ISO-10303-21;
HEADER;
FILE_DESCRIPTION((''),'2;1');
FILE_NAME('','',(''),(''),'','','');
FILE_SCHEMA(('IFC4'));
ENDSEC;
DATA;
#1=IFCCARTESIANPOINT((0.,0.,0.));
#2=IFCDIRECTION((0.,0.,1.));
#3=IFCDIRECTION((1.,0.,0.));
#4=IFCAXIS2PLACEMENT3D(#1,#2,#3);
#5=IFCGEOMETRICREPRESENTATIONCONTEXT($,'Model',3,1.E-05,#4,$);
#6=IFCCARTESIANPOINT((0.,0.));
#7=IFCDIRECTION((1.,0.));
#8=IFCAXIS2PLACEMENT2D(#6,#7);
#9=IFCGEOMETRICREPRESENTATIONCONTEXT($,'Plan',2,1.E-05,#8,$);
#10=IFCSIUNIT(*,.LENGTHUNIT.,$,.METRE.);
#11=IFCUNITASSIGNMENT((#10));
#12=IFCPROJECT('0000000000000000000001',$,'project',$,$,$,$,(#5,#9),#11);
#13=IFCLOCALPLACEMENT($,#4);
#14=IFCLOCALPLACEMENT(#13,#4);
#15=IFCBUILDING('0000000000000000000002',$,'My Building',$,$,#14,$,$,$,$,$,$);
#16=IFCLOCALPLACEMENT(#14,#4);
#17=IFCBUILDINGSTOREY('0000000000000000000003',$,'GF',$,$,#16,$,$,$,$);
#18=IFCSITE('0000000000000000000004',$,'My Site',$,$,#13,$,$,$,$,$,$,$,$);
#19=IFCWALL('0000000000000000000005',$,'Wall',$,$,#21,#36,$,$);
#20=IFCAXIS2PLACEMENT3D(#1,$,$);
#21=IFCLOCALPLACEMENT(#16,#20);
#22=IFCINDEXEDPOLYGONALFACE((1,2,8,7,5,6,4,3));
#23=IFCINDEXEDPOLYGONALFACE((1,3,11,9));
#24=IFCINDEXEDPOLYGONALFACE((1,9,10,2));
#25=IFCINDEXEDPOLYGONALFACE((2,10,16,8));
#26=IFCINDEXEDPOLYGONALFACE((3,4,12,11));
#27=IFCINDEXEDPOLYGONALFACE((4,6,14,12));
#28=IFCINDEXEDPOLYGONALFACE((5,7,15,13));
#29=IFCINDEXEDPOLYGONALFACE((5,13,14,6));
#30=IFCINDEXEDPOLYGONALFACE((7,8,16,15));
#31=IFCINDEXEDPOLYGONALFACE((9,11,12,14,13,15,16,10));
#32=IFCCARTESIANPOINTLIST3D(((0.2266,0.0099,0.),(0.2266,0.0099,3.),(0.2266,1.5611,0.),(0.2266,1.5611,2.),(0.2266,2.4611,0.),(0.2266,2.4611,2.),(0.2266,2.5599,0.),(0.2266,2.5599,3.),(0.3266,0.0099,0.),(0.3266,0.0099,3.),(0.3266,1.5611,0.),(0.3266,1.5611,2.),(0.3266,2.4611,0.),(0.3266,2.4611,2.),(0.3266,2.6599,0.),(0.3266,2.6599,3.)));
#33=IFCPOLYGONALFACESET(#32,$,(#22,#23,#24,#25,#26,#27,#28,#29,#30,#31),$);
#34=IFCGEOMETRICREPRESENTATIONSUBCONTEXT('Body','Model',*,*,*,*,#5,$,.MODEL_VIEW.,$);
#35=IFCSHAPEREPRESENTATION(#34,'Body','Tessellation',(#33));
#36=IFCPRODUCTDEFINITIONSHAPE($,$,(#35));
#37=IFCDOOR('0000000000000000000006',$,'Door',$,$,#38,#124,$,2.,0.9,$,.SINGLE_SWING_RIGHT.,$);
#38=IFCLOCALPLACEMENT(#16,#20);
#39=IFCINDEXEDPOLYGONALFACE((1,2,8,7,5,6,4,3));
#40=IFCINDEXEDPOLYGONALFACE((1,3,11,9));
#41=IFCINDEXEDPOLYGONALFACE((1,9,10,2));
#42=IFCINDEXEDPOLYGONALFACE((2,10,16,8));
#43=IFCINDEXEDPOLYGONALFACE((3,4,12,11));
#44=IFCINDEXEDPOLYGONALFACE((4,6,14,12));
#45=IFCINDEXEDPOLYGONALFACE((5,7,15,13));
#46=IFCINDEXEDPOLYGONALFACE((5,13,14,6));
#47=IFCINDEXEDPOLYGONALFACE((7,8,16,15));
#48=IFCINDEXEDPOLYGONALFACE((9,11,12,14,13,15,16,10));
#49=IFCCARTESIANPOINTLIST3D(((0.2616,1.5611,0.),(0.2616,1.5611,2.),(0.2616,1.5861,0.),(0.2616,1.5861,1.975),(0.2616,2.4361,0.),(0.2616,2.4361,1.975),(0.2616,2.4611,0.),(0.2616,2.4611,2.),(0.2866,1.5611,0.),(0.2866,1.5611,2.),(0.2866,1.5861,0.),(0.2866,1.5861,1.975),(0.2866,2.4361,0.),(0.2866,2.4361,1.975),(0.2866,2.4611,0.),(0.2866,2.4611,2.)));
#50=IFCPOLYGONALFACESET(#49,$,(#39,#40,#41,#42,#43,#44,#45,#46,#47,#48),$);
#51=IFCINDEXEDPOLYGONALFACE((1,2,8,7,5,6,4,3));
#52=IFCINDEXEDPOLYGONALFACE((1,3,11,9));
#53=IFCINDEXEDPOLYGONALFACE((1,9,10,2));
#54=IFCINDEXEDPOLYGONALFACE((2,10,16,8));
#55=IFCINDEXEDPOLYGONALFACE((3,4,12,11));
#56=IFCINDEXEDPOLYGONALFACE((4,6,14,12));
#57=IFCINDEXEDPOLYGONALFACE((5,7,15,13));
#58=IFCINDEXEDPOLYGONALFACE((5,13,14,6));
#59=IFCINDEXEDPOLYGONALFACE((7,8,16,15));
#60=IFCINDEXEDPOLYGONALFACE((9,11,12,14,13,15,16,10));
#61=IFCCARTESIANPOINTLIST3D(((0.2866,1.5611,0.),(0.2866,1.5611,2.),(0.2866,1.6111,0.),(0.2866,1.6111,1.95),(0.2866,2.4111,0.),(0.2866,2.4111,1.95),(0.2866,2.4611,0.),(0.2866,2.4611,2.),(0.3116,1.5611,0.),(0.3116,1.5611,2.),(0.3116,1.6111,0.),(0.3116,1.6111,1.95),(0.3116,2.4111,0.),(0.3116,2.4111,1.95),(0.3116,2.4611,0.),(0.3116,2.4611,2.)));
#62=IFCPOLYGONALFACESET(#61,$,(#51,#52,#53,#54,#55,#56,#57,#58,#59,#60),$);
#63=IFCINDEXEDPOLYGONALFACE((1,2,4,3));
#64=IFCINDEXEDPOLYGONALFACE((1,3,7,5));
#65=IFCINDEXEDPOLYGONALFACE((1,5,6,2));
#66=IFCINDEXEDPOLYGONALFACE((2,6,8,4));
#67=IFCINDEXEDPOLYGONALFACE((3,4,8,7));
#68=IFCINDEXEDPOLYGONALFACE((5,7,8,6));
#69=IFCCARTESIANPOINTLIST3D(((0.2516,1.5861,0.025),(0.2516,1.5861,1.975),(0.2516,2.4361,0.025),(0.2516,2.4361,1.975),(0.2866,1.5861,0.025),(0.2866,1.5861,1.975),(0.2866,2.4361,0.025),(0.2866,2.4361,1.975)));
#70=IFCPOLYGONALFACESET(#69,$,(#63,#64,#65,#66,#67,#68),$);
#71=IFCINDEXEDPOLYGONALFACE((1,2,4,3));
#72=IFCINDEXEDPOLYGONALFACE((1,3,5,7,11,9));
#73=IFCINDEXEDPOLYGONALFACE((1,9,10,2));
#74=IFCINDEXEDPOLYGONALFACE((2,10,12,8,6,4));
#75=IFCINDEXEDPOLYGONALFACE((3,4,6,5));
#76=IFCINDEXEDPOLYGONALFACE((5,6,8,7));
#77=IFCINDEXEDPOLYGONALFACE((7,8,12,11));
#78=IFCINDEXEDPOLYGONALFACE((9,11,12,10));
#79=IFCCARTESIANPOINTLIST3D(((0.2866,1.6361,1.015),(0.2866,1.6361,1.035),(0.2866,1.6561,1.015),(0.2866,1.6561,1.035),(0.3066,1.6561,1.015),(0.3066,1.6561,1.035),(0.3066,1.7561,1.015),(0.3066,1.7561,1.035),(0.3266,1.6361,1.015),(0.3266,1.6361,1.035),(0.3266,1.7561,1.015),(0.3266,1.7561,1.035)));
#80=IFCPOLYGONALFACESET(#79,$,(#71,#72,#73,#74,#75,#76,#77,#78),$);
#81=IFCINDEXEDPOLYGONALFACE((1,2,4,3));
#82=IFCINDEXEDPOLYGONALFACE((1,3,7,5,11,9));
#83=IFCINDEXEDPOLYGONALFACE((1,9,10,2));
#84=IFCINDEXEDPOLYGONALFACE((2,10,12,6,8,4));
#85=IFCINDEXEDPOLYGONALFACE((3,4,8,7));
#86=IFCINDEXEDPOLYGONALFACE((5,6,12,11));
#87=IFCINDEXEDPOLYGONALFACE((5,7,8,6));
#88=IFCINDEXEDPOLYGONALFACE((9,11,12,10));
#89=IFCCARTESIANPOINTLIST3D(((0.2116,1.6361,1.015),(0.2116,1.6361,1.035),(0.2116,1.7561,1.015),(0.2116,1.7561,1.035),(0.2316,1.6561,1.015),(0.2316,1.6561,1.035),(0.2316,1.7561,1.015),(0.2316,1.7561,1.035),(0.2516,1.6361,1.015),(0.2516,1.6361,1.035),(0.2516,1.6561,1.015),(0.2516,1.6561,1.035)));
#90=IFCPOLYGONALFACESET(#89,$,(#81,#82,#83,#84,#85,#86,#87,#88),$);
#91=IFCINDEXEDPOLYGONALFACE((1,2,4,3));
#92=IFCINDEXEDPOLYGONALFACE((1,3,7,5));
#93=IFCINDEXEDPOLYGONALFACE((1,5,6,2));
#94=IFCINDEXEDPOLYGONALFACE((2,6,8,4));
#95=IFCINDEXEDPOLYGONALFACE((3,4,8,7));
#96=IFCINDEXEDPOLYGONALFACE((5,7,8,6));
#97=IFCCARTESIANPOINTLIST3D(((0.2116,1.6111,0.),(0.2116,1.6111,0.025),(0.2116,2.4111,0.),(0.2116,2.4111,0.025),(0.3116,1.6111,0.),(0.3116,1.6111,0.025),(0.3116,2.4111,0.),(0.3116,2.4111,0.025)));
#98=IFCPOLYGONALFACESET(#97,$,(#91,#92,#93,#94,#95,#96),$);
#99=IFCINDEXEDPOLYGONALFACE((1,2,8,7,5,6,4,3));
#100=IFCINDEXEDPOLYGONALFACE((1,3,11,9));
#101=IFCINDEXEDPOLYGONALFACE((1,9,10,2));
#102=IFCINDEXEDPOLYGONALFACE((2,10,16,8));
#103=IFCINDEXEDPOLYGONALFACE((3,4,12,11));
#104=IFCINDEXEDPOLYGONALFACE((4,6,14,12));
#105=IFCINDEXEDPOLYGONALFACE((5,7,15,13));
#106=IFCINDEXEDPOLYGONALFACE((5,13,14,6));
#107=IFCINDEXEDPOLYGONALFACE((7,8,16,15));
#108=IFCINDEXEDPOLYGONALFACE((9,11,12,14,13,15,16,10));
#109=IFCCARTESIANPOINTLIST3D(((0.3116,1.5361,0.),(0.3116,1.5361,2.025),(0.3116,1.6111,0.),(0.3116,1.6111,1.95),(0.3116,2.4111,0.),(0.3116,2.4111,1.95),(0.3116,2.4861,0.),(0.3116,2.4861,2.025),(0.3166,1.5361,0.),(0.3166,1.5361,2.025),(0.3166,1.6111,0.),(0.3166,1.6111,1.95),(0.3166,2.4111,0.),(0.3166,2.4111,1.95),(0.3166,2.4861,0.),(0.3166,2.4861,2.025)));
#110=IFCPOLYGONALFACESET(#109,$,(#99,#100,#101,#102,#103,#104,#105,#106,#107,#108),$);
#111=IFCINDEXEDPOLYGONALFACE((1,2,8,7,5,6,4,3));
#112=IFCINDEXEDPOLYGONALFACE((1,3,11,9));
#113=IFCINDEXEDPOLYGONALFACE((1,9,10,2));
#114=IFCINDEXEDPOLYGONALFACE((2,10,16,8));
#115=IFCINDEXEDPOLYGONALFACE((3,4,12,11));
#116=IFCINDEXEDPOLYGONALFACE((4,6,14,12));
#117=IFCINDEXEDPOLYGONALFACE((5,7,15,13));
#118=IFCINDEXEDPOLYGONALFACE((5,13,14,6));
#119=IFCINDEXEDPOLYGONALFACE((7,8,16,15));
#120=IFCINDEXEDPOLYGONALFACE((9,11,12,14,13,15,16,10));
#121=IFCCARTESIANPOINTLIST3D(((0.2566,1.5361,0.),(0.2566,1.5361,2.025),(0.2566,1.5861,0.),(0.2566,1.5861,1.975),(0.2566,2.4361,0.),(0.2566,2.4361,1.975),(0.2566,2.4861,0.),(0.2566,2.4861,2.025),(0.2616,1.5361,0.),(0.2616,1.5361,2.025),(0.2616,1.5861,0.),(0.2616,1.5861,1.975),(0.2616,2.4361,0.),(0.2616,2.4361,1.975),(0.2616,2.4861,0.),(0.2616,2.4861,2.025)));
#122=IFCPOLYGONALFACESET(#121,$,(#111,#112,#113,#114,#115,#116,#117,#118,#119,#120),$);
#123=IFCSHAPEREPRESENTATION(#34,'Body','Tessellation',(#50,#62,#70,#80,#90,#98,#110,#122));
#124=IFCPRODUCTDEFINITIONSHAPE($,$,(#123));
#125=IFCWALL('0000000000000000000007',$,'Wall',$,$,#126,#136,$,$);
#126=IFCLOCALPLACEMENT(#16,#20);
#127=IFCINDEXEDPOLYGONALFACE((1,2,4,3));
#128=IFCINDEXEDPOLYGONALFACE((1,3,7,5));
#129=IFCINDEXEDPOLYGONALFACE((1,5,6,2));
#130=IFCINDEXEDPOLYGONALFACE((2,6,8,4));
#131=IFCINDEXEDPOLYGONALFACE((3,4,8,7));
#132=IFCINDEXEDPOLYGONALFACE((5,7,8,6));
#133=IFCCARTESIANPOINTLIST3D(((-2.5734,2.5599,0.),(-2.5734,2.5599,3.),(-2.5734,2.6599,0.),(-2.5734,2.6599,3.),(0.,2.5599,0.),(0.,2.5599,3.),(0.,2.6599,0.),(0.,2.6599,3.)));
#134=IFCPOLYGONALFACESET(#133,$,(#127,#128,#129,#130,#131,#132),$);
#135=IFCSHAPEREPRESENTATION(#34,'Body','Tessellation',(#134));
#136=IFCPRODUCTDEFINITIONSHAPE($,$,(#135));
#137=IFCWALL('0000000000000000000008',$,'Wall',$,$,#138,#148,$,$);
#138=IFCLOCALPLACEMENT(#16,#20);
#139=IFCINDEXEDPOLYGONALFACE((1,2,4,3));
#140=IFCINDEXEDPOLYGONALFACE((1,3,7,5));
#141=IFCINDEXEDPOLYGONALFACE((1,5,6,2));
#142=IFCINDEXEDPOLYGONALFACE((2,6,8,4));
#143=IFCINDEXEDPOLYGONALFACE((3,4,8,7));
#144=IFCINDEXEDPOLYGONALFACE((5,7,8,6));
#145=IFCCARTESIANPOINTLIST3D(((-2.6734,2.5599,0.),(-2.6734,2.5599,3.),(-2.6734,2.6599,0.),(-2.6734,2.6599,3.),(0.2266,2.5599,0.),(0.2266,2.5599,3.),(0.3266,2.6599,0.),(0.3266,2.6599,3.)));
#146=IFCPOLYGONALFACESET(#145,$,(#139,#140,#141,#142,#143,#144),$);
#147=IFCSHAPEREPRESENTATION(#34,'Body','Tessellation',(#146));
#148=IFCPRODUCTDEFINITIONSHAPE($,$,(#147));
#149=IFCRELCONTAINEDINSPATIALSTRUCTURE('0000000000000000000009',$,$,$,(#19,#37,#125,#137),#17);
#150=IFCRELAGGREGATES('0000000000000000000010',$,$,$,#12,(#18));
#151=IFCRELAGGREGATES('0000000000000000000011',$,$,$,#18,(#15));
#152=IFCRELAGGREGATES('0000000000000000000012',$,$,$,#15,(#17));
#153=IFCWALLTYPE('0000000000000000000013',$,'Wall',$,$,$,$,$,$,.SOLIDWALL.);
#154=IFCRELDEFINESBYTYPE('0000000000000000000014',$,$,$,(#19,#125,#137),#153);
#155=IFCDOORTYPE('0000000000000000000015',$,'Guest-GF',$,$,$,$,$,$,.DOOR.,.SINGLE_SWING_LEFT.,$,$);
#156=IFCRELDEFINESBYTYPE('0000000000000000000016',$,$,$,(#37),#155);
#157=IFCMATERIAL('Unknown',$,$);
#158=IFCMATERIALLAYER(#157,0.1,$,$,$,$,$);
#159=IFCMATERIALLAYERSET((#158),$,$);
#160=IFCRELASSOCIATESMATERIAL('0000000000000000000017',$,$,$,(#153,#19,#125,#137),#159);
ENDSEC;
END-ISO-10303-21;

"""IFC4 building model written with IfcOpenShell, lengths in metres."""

from ifc_helpers import new_model, entity, si_unit, frame, origin_with_axes, origin_2d_with_axis, place, context, subcontext, project, spatial, line, indexed_curve, outline, extrude, shape, source, transform, mapped, material, layer, layer_set, layer_usage, type_object, type_shapes, element, fill, save


model = new_model("IFC4")

# Units and contexts
model_context = context("Model", 3, precision=1e-05, world=origin_with_axes())
plan_context = context("Plan", 2, precision=1e-05, world=origin_2d_with_axis())
body_context_1 = subcontext(model_context, "Body", "Model", "MODEL_VIEW")
body_context_2 = subcontext(plan_context, "Body", "Plan", "PLAN_VIEW")
ifc_project = project(units=[si_unit("LENGTHUNIT", "METRE")], contexts=[model_context, plan_context])

# Site, building, storey
site_placement = place(None, origin_with_axes())
site = spatial("IfcSite", under=ifc_project, at=site_placement, Name="My Site")
building_placement = place(site_placement, origin_with_axes())
building = spatial("IfcBuilding", under=site, at=building_placement, Name="My Building")
storey_placement = place(building_placement, origin_with_axes())
storey = spatial("IfcBuildingStorey", under=building, at=storey_placement, Name="GF")

# Shared definitions
ifc_material = material(Name="Unknown")

# Shared definitions
ifc_layer_1 = layer(ifc_material, 0.1)
ifc_layer_set_1 = layer_set([ifc_layer_1])
wall_type = type_object("IfcWallType", Name="Wall", PredefinedType="SOLIDWALL", material=ifc_layer_set_1)

# Wall, opening, door
ifc_layer_usage_1 = layer_usage(ifc_layer_set_1, "AXIS2", "POSITIVE", 0.0)
wall_1_placement = place(storey_placement, frame((0.3266, 0.0099, 0.0), z_axis=(0.0, 0.0, 1.0), x_axis=(0.0, 1.0, 0.0)))
wall_1 = element("IfcWall", 1, at=wall_1_placement, inside=storey, type_object=wall_type, material=ifc_layer_usage_1, Name="Wall", context=body_context_1, shape_type="SweptSolid", body=[
    extrude(outline(indexed_curve([(0.0, 0.0), (0.0, 0.1), (2.55, 0.1), (2.65, 0.0)], segments=[line(1, 2, 3, 4, 1)])), origin_with_axes(), (0.0, 0.0, 1.0), 3.0),
])
shared_shape_1 = source(origin_with_axes(), body_context_1, "Body", "SweptSolid", [
    extrude(outline(indexed_curve([(0.0, 0.0), (0.9, 0.0), (0.9, 2.0), (0.0, 2.0)], segments=[line(1, 2, 3, 4, 1)])), frame((0.0, -0.6, 0.0), z_axis=(0.0, -1.0, 0.0), x_axis=(1.0, 0.0, 0.0)), (0.0, 0.0, -1.0), 1.2),
])
opening_1_placement = place(wall_1_placement, frame((1.5512, 0.015, 0.0), z_axis=(0.0, 0.0, 1.0), x_axis=(1.0, 0.0, 0.0)))
opening_1 = element("IfcOpeningElement", 2, at=opening_1_placement, cuts=wall_1, PredefinedType="OPENING", context=body_context_1, shape_type="MappedRepresentation", body=[
    mapped(shared_shape_1, transform((0.0, 0.0, 0.0), x_axis=(1.0, 0.0, 0.0), y_axis=(0.0, 1.0, 0.0), z_axis=(0.0, 0.0, 1.0), scale=1.0)),
])
door_type_1 = type_object("IfcDoorType", Name="Guest-GF", OperationType="SINGLE_SWING_LEFT", PredefinedType="DOOR")
shared_shape_2 = source(origin_with_axes(), body_context_1, "Body", "SweptSolid", [
    extrude(outline(indexed_curve([(0.0, 0.0), (0.0, 2.0), (0.9, 2.0), (0.9, 0.0), (0.875, 0.0), (0.875, 1.975), (0.025, 1.975), (0.025, 0.0)], segments=[line(1, 2, 3, 4, 5, 6, 7, 8, 1)])), frame((0.0, 0.025, 0.0), z_axis=(0.0, -1.0, 0.0), x_axis=(1.0, 0.0, 0.0)), (0.0, 0.0, -1.0), 0.025),
    extrude(outline(indexed_curve([(0.0, 0.0), (0.0, 2.0), (0.9, 2.0), (0.9, 0.0), (0.85, 0.0), (0.85, 1.95), (0.05, 1.95), (0.05, 0.0)], segments=[line(1, 2, 3, 4, 5, 6, 7, 8, 1)])), frame((0.0, 0.0, 0.0), z_axis=(0.0, -1.0, 0.0), x_axis=(1.0, 0.0, 0.0)), (0.0, 0.0, -1.0), 0.025),
    extrude(outline(indexed_curve([(0.0, 0.0), (0.85, 0.0), (0.85, 0.035), (0.0, 0.035)], segments=[line(1, 2, 3, 4, 1)])), frame((0.025, 0.025, 0.025), z_axis=(0.0, 0.0, 1.0), x_axis=(1.0, 0.0, 0.0)), (0.0, 0.0, 1.0), 1.95),
    extrude(outline(indexed_curve([(0.0, 0.0), (0.0, -0.04), (0.12, -0.04), (0.12, -0.02), (0.02, -0.02), (0.02, 0.0)], segments=[line(1, 2, 3, 4, 5, 6, 1)])), frame((0.075, 0.025, 1.015), z_axis=(0.0, 0.0, 1.0), x_axis=(1.0, 0.0, 0.0)), (0.0, 0.0, 1.0), 0.02),
    extrude(outline(indexed_curve([(0.0, 0.0), (0.0, 0.04), (0.12, 0.04), (0.12, 0.02), (0.02, 0.02), (0.02, 0.0)], segments=[line(1, 2, 3, 4, 5, 6, 1)])), frame((0.075, 0.06, 1.015), z_axis=(0.0, 0.0, 1.0), x_axis=(1.0, 0.0, 0.0)), (0.0, 0.0, 1.0), 0.02),
    extrude(outline(indexed_curve([(0.0, 0.0), (0.8, 0.0), (0.8, 0.1), (0.0, 0.1)], segments=[line(1, 2, 3, 4, 1)])), frame((0.05, 0.0, 0.0), z_axis=(0.0, 0.0, 1.0), x_axis=(1.0, 0.0, 0.0)), (0.0, 0.0, 1.0), 0.025),
    extrude(outline(indexed_curve([(0.0, 0.0), (0.0, 2.025), (0.95, 2.025), (0.95, 0.0), (0.875, 0.0), (0.875, 1.95), (0.075, 1.95), (0.075, 0.0)], segments=[line(1, 2, 3, 4, 5, 6, 7, 8, 1)])), frame((-0.025, -0.005, 0.0), z_axis=(0.0, -1.0, 0.0), x_axis=(1.0, 0.0, 0.0)), (0.0, 0.0, -1.0), 0.005),
    extrude(outline(indexed_curve([(0.0, 0.0), (0.0, 2.025), (0.95, 2.025), (0.95, 0.0), (0.9, 0.0), (0.9, 1.975), (0.05, 1.975), (0.05, 0.0)], segments=[line(1, 2, 3, 4, 5, 6, 7, 8, 1)])), frame((-0.025, 0.05, 0.0), z_axis=(0.0, -1.0, 0.0), x_axis=(1.0, 0.0, 0.0)), (0.0, 0.0, -1.0), 0.005),
])
shared_shape_3 = source(origin_with_axes(), body_context_2, "Body", "Curve2D", [
    entity("IfcIndexedPolyCurve", entity("IfcCartesianPointList2D", [[0.0, 0.0], [0.0, 0.05], [0.025, 0.05], [0.025, 0.025], [0.05, 0.025], [0.05, 0.0]]), [entity("IfcLineIndex", [1, 2, 3, 4, 5, 6, 1])]),
    entity("IfcIndexedPolyCurve", entity("IfcCartesianPointList2D", [[0.9, 0.0], [0.9, 0.05], [0.875, 0.05], [0.875, 0.025], [0.85, 0.025], [0.85, 0.0]]), [entity("IfcLineIndex", [1, 2, 3, 4, 5, 6, 1])]),
    entity("IfcTrimmedCurve", entity("IfcEllipse", entity("IfcAxis2Placement2D", entity("IfcCartesianPoint", [0.84, 0.05]), entity("IfcDirection", [1.0, 0.0])), 0.815, 0.85), [entity("IfcCartesianPoint", [0.84, 0.9])], [entity("IfcCartesianPoint", [0.025, 0.05])], True, "CARTESIAN"),
    entity("IfcIndexedPolyCurve", entity("IfcCartesianPointList2D", [[0.875, 0.05], [0.84, 0.05], [0.84, 0.9], [0.875, 0.9]]), [entity("IfcLineIndex", [1, 2, 3, 4, 1])]),
])
type_shapes(door_type_1, [shared_shape_2, shared_shape_3])
door_1_placement = place(opening_1_placement, frame((0.0, 0.0, 0.0), z_axis=(0.0, 0.0, 1.0), x_axis=(1.0, 0.0, 0.0)))
door_1 = element("IfcDoor", 3, at=door_1_placement, inside=storey, type_object=door_type_1, Name="Door", OperationType="SINGLE_SWING_RIGHT", OverallHeight=2.0, OverallWidth=0.9, shapes=[
    shape(body_context_1, "Body", "MappedRepresentation", [mapped(shared_shape_2, transform((0.0, 0.0, 0.0), x_axis=(1.0, 0.0, 0.0), y_axis=(0.0, 1.0, 0.0), z_axis=(0.0, 0.0, 1.0), scale=1.0))]),
    shape(body_context_2, "Body", "MappedRepresentation", [mapped(shared_shape_3, transform((0.0, 0.0, 0.0), x_axis=(1.0, 0.0, 0.0), y_axis=(0.0, 1.0, 0.0), z_axis=(0.0, 0.0, 1.0), scale=1.0))]),
])
fill(opening_1, door_1)

# Walls
ifc_layer_usage_2 = layer_usage(ifc_layer_set_1, "AXIS2", "POSITIVE", 0.0)
wall_2_placement = place(storey_placement, frame((0.0, 2.6599, 0.0), z_axis=(0.0, 0.0, 1.0), x_axis=(-1.0, 0.0, 0.0)))
element("IfcWall", 4, at=wall_2_placement, inside=storey, type_object=wall_type, material=ifc_layer_usage_2, Name="Wall", context=body_context_1, shape_type="SweptSolid", body=[
    extrude(outline(indexed_curve([(0.0, 0.0), (0.0, 0.1), (2.5734, 0.1), (2.5734, 0.0)], segments=[line(1, 2, 3, 4, 1)])), origin_with_axes(), (0.0, 0.0, 1.0), 3.0),
])
ifc_layer_usage_3 = layer_usage(ifc_layer_set_1, "AXIS2", "POSITIVE", 0.0)
wall_3_placement = place(storey_placement, frame((0.3266, 2.6599, 0.0), z_axis=(0.0, 0.0, 1.0), x_axis=(-1.0, 0.0, 0.0)))
element("IfcWall", 5, at=wall_3_placement, inside=storey, type_object=wall_type, material=ifc_layer_usage_3, Name="Wall", context=body_context_1, shape_type="SweptSolid", body=[
    extrude(outline(indexed_curve([(0.0, 0.0), (0.1, 0.1), (3.0, 0.1), (3.0, 0.0)], segments=[line(1, 2, 3, 4, 1)])), origin_with_axes(), (0.0, 0.0, 1.0), 3.0),
])

save(model, "model.ifc")
